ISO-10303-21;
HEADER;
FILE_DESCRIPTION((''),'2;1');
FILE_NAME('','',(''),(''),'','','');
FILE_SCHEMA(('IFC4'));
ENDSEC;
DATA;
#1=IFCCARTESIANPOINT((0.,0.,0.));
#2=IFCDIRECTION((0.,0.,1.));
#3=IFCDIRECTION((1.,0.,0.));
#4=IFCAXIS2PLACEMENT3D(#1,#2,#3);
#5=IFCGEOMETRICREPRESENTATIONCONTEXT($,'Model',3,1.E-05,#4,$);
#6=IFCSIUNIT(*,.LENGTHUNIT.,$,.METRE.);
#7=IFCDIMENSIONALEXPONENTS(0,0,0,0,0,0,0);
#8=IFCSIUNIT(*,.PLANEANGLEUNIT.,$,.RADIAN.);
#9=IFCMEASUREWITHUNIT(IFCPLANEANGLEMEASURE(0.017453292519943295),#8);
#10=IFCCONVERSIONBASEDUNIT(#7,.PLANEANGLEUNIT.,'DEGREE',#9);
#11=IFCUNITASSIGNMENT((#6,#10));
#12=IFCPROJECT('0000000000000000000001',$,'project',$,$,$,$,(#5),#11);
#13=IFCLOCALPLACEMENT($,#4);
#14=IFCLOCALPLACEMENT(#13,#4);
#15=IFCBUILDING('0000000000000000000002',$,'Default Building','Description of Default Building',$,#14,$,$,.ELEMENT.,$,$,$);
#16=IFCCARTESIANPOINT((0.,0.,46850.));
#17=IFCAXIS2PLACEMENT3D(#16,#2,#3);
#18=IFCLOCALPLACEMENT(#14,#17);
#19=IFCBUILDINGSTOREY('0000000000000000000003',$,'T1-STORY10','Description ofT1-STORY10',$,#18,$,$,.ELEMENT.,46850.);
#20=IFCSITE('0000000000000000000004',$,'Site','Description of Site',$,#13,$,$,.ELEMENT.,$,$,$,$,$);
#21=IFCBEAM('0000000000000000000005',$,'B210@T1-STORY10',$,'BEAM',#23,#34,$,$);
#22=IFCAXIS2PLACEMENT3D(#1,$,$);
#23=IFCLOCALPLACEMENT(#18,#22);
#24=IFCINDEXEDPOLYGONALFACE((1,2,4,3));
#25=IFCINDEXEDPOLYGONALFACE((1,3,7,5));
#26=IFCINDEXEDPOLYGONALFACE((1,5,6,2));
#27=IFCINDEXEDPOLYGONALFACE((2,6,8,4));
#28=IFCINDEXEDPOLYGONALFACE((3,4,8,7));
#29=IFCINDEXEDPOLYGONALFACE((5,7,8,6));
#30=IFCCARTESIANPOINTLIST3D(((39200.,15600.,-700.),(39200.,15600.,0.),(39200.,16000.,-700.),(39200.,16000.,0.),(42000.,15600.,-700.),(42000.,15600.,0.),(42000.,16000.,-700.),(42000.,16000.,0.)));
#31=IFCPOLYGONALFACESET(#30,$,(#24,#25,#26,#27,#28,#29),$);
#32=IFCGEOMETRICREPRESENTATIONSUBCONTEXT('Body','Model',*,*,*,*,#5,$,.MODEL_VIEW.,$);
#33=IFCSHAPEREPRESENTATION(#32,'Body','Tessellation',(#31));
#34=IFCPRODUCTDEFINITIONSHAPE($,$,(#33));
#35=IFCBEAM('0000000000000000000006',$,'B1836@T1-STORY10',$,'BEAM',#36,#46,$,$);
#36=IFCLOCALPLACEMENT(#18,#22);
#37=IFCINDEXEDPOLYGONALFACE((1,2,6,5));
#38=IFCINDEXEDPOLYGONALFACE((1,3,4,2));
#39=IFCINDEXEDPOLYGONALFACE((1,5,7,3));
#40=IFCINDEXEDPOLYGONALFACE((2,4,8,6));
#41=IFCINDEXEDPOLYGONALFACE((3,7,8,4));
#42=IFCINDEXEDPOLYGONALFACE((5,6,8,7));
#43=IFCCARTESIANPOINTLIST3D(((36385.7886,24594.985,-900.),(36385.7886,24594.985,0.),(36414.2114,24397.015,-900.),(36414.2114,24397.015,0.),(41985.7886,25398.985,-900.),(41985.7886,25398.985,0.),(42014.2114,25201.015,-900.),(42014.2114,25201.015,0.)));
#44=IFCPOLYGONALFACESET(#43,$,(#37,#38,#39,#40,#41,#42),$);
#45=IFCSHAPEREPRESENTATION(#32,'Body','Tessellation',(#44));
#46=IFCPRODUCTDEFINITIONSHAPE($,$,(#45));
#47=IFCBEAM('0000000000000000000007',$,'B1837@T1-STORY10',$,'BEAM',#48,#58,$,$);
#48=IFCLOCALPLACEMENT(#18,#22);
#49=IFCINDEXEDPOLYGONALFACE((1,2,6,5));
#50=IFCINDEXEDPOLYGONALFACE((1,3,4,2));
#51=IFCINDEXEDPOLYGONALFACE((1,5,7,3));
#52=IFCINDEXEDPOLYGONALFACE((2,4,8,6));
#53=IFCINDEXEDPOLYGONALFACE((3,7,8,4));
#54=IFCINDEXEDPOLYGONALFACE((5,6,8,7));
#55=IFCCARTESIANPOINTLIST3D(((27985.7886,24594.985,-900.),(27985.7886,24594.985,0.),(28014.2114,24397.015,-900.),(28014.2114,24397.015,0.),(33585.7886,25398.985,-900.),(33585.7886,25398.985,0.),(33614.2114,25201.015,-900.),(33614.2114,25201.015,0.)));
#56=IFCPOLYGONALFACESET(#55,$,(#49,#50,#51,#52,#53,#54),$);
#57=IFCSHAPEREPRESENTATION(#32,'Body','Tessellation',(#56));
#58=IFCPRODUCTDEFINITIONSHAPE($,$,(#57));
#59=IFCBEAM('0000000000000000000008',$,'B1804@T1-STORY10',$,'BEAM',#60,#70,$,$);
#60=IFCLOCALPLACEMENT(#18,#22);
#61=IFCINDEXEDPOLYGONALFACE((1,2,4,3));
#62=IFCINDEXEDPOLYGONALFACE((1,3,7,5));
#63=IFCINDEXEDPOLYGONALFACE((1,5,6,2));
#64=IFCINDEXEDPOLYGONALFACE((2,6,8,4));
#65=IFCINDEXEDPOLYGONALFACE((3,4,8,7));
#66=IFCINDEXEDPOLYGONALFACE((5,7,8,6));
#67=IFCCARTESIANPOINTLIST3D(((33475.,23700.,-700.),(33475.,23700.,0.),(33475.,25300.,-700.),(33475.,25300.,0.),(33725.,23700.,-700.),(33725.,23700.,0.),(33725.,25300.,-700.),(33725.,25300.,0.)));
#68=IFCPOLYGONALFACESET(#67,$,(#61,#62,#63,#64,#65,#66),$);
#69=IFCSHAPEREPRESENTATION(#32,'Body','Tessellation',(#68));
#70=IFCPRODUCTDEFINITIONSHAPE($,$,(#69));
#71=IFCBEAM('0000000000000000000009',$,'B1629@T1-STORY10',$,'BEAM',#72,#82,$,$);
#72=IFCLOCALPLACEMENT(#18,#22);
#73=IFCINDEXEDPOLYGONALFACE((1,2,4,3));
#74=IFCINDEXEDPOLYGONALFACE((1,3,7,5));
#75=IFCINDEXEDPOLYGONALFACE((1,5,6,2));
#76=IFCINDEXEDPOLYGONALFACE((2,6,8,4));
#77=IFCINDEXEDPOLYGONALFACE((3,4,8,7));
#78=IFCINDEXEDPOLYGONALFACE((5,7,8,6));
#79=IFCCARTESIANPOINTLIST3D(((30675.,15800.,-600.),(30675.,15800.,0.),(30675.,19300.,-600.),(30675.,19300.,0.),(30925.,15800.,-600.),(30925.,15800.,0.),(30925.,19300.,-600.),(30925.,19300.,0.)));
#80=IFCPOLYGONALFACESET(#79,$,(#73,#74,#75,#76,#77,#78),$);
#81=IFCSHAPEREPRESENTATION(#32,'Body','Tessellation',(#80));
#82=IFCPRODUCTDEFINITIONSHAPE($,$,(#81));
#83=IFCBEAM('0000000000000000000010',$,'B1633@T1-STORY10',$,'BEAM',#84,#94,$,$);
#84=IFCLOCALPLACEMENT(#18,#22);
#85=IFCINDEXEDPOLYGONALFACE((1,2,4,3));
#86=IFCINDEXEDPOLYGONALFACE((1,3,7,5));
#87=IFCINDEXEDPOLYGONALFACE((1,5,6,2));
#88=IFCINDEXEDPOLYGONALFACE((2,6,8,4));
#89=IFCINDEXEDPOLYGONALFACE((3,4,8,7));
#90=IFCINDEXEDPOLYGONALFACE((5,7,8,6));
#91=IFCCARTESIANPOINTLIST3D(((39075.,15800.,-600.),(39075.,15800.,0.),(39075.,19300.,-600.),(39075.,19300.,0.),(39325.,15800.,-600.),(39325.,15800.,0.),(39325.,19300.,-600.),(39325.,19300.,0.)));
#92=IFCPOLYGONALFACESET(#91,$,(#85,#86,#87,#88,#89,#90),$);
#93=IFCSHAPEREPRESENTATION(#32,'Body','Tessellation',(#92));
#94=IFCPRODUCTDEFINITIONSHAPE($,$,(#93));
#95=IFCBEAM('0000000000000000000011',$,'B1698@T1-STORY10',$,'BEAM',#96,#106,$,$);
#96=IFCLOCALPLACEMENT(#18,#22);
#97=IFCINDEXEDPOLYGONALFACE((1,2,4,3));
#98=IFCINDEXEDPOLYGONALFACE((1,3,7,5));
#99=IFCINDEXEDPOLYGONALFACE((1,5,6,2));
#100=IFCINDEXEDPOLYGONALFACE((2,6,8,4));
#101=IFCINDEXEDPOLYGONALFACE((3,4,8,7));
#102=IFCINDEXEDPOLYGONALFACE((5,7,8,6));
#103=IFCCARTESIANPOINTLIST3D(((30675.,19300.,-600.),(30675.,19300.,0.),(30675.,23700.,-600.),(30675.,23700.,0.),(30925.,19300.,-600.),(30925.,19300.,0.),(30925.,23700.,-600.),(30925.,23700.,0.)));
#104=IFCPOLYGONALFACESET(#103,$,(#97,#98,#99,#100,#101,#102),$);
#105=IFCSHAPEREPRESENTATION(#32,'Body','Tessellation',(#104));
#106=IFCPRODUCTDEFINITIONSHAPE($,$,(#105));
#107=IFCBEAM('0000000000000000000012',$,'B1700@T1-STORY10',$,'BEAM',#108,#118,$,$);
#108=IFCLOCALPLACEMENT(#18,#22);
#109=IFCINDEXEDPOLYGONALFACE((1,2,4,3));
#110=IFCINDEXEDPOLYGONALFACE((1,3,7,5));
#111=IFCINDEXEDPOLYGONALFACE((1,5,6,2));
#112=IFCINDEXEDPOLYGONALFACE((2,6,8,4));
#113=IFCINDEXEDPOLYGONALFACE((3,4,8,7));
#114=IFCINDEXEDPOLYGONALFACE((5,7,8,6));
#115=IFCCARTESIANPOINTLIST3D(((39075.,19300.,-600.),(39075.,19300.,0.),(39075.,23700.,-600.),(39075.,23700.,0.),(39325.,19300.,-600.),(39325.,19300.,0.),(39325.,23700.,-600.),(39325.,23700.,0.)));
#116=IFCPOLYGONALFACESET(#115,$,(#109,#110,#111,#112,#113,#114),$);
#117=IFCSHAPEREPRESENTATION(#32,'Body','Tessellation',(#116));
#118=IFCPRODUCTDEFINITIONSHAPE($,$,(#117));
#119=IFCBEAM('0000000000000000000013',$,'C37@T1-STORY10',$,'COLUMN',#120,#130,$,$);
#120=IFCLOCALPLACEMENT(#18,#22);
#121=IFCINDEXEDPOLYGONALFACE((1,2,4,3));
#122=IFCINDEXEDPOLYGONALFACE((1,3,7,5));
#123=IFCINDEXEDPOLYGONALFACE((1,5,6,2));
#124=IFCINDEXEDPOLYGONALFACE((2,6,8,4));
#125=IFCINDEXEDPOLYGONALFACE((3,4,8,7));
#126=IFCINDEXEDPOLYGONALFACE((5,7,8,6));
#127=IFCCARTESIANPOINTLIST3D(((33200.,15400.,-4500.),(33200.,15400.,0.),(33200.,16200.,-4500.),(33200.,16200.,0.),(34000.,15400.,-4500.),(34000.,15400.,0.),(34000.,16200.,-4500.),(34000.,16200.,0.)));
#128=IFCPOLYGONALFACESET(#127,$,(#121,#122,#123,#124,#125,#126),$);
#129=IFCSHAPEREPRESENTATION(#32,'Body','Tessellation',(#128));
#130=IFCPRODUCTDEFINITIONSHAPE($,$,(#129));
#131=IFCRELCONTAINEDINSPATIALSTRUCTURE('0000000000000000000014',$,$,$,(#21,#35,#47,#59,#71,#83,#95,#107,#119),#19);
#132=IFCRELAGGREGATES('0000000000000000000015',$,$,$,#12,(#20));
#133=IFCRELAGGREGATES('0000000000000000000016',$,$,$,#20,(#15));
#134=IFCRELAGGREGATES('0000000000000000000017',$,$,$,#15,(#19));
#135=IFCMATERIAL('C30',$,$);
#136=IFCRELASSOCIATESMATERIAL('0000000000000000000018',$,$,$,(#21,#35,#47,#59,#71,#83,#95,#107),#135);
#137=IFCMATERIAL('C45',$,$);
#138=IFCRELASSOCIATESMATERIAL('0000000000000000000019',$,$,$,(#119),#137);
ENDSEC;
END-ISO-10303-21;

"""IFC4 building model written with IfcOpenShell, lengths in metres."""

from ifc_helpers import new_model, entity, si_unit, converted_unit, frame, origin_with_axes, place, context, subcontext, project, spatial, rectangle, extrude, material, element, save


model = new_model("IFC4")

# Units and contexts
model_context = context("Model", 3, precision=1e-05, world=origin_with_axes())
body_context = subcontext(model_context, "Body", "Model", "MODEL_VIEW")
ifc_project = project(units=[si_unit("LENGTHUNIT", "METRE"), converted_unit("PLANEANGLEUNIT", "DEGREE", entity("IfcPlaneAngleMeasure", 0.017453292519943295), si_unit("PLANEANGLEUNIT", "RADIAN"), dimensions=[0, 0, 0, 0, 0, 0, 0])], contexts=[model_context])

# Site, building, storey
site_placement = place(None, origin_with_axes())
site = spatial("IfcSite", under=ifc_project, at=site_placement, Name="Site", Description="Description of Site", CompositionType="ELEMENT")
building_placement = place(site_placement, origin_with_axes())
building = spatial("IfcBuilding", under=site, at=building_placement, Name="Default Building", Description="Description of Default Building", CompositionType="ELEMENT")
storey_placement = place(building_placement, frame((0.0, 0.0, 46850.0), z_axis=(0.0, 0.0, 1.0), x_axis=(1.0, 0.0, 0.0)))
storey = spatial("IfcBuildingStorey", under=building, at=storey_placement, Name="T1-STORY10", Description="Description ofT1-STORY10", CompositionType="ELEMENT", Elevation=46850.0)

# Beams
ifc_material_1 = material(Name="C30")
for number, where, z_axis, x_axis, name in (
    (1, (39200.0, 15800.0, -350.0), (1.0, 0.0, 0.0), (0.0, 1.0, 0.0), "B210@T1-STORY10"),
):
    element("IfcBeam", number, at=place(storey_placement, frame(where, z_axis=z_axis, x_axis=x_axis)), inside=storey, material=ifc_material_1, Name=name, ObjectType="BEAM", context=body_context, shape_type="SweptSolid", body=[
        extrude(rectangle(XDim=400.0, YDim=700.0), origin_with_axes(), (0.0, 0.0, 1.0), 2800.0),
    ])
for number, where, z_axis, x_axis, name in (
    (2, (36400.0, 24496.0, -450.0), (0.98985, 0.142114, 0.0), (-0.142114, 0.98985, 0.0), "B1836@T1-STORY10"),
    (3, (28000.0, 24496.0, -450.0), (0.98985, 0.142114, 0.0), (-0.142114, 0.98985, 0.0), "B1837@T1-STORY10"),
):
    element("IfcBeam", number, at=place(storey_placement, frame(where, z_axis=z_axis, x_axis=x_axis)), inside=storey, material=ifc_material_1, Name=name, ObjectType="BEAM", context=body_context, shape_type="SweptSolid", body=[
        extrude(rectangle(XDim=200.0, YDim=900.0), origin_with_axes(), (0.0, 0.0, 1.0), 5657.4213),
    ])
beam_1_placement = place(storey_placement, frame((33600.0, 23700.0, -350.0), z_axis=(0.0, 1.0, 0.0), x_axis=(-1.0, 0.0, 0.0)))
element("IfcBeam", 4, at=beam_1_placement, inside=storey, material=ifc_material_1, Name="B1804@T1-STORY10", ObjectType="BEAM", context=body_context, shape_type="SweptSolid", body=[
    extrude(rectangle(XDim=250.0, YDim=700.0), origin_with_axes(), (0.0, 0.0, 1.0), 1600.0),
])
for number, where, z_axis, x_axis, name in (
    (5, (30800.0, 15800.0, -300.0), (0.0, 1.0, 0.0), (-1.0, 0.0, 0.0), "B1629@T1-STORY10"),
    (6, (39200.0, 15800.0, -300.0), (0.0, 1.0, 0.0), (-1.0, 0.0, 0.0), "B1633@T1-STORY10"),
):
    element("IfcBeam", number, at=place(storey_placement, frame(where, z_axis=z_axis, x_axis=x_axis)), inside=storey, material=ifc_material_1, Name=name, ObjectType="BEAM", context=body_context, shape_type="SweptSolid", body=[
        extrude(rectangle(XDim=250.0, YDim=600.0), origin_with_axes(), (0.0, 0.0, 1.0), 3500.0),
    ])
for number, where, z_axis, x_axis, name in (
    (7, (30800.0, 19300.0, -300.0), (0.0, 1.0, 0.0), (-1.0, 0.0, 0.0), "B1698@T1-STORY10"),
    (8, (39200.0, 19300.0, -300.0), (0.0, 1.0, 0.0), (-1.0, 0.0, 0.0), "B1700@T1-STORY10"),
):
    element("IfcBeam", number, at=place(storey_placement, frame(where, z_axis=z_axis, x_axis=x_axis)), inside=storey, material=ifc_material_1, Name=name, ObjectType="BEAM", context=body_context, shape_type="SweptSolid", body=[
        extrude(rectangle(XDim=250.0, YDim=600.0), origin_with_axes(), (0.0, 0.0, 1.0), 4400.0),
    ])
ifc_material_2 = material(Name="C45")
beam_2_placement = place(storey_placement, frame((33600.0, 15800.0, -4500.0), z_axis=(0.0, 0.0, 1.0), x_axis=(-1.0, 0.0, 0.0)))
element("IfcBeam", 9, at=beam_2_placement, inside=storey, material=ifc_material_2, Name="C37@T1-STORY10", ObjectType="COLUMN", context=body_context, shape_type="SweptSolid", body=[
    extrude(rectangle(XDim=800.0, YDim=800.0), origin_with_axes(), (0.0, 0.0, 1.0), 4500.0),
])

save(model, "model.ifc")
